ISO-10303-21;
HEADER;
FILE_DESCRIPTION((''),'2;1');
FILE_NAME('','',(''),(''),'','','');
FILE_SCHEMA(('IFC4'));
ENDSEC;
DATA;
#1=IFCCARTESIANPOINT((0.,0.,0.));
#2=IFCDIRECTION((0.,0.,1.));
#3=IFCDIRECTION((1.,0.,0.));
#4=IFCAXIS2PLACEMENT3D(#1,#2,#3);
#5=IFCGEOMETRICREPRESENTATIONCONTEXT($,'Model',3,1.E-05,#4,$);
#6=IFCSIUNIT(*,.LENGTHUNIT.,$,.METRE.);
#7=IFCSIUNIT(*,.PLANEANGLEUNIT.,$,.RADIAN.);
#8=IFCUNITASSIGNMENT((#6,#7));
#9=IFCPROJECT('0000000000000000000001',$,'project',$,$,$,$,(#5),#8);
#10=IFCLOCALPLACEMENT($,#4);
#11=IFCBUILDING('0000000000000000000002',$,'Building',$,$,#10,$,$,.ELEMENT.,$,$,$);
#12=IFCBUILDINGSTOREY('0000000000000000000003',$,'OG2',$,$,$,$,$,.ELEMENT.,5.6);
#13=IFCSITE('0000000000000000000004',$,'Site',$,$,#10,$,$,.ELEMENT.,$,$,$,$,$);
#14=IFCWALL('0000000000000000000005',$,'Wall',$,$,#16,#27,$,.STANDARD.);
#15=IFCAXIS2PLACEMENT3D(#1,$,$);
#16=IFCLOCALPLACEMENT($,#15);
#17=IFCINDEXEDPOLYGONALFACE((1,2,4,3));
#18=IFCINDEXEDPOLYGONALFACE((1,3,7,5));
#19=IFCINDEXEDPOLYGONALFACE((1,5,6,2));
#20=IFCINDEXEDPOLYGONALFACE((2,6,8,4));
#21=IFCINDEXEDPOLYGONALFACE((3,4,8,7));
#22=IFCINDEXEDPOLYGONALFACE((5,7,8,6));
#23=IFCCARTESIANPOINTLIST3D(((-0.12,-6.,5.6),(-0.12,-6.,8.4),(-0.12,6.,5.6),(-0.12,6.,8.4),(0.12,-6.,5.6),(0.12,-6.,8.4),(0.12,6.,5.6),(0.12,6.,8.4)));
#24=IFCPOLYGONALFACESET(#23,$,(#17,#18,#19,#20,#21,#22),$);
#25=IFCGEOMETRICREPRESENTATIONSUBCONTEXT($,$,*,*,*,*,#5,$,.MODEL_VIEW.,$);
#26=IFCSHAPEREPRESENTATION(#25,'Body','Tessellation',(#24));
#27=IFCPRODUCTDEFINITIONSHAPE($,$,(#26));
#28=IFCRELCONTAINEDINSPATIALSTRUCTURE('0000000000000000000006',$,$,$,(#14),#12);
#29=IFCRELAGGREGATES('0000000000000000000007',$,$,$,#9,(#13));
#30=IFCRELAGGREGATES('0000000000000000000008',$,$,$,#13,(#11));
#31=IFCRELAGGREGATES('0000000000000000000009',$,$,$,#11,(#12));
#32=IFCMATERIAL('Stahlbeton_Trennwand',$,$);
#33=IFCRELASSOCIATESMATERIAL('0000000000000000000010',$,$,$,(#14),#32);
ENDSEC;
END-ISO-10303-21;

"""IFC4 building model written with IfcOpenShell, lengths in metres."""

from ifc_helpers import new_model, si_unit, frame, frame_2d, origin, origin_with_axes, place, context, subcontext, project, spatial, rectangle, extrude, material, element, save


model = new_model("IFC4")

# Units and contexts
model_context = context("Model", 3, precision=1e-05, world=origin_with_axes())
sub_context = subcontext(model_context, None, None, "MODEL_VIEW")
ifc_project = project(units=[si_unit("LENGTHUNIT", "METRE"), si_unit("PLANEANGLEUNIT", "RADIAN")], contexts=[model_context])

# Site, building, storey
placement_1 = place(None, origin_with_axes())
site = spatial("IfcSite", under=ifc_project, at=placement_1, Name="Site", CompositionType="ELEMENT")
building = spatial("IfcBuilding", under=site, at=placement_1, Name="Building", CompositionType="ELEMENT")
storey = spatial("IfcBuildingStorey", under=building, Name="OG2", CompositionType="ELEMENT", Elevation=5.6)

# Wall
ifc_material = material(Name="Stahlbeton_Trennwand")
placement_2 = place(None, origin_with_axes())
placement_3 = place(placement_2, frame((0.0, 0.0, 5.6)))
wall_placement = place(placement_3, frame((0.0, -6.0, 0.0), x_axis=(0.0, 1.0, 0.0)))
element("IfcWall", 1, at=wall_placement, inside=storey, material=ifc_material, Name="Wall", PredefinedType="STANDARD", context=sub_context, shape_type="SweptSolid", body=[
    extrude(rectangle(XDim=12.0, YDim=0.24, at=frame_2d((6.0, 0.0))), origin(), (0.0, 0.0, 1.0), 2.8),
])

save(model, "model.ifc")
